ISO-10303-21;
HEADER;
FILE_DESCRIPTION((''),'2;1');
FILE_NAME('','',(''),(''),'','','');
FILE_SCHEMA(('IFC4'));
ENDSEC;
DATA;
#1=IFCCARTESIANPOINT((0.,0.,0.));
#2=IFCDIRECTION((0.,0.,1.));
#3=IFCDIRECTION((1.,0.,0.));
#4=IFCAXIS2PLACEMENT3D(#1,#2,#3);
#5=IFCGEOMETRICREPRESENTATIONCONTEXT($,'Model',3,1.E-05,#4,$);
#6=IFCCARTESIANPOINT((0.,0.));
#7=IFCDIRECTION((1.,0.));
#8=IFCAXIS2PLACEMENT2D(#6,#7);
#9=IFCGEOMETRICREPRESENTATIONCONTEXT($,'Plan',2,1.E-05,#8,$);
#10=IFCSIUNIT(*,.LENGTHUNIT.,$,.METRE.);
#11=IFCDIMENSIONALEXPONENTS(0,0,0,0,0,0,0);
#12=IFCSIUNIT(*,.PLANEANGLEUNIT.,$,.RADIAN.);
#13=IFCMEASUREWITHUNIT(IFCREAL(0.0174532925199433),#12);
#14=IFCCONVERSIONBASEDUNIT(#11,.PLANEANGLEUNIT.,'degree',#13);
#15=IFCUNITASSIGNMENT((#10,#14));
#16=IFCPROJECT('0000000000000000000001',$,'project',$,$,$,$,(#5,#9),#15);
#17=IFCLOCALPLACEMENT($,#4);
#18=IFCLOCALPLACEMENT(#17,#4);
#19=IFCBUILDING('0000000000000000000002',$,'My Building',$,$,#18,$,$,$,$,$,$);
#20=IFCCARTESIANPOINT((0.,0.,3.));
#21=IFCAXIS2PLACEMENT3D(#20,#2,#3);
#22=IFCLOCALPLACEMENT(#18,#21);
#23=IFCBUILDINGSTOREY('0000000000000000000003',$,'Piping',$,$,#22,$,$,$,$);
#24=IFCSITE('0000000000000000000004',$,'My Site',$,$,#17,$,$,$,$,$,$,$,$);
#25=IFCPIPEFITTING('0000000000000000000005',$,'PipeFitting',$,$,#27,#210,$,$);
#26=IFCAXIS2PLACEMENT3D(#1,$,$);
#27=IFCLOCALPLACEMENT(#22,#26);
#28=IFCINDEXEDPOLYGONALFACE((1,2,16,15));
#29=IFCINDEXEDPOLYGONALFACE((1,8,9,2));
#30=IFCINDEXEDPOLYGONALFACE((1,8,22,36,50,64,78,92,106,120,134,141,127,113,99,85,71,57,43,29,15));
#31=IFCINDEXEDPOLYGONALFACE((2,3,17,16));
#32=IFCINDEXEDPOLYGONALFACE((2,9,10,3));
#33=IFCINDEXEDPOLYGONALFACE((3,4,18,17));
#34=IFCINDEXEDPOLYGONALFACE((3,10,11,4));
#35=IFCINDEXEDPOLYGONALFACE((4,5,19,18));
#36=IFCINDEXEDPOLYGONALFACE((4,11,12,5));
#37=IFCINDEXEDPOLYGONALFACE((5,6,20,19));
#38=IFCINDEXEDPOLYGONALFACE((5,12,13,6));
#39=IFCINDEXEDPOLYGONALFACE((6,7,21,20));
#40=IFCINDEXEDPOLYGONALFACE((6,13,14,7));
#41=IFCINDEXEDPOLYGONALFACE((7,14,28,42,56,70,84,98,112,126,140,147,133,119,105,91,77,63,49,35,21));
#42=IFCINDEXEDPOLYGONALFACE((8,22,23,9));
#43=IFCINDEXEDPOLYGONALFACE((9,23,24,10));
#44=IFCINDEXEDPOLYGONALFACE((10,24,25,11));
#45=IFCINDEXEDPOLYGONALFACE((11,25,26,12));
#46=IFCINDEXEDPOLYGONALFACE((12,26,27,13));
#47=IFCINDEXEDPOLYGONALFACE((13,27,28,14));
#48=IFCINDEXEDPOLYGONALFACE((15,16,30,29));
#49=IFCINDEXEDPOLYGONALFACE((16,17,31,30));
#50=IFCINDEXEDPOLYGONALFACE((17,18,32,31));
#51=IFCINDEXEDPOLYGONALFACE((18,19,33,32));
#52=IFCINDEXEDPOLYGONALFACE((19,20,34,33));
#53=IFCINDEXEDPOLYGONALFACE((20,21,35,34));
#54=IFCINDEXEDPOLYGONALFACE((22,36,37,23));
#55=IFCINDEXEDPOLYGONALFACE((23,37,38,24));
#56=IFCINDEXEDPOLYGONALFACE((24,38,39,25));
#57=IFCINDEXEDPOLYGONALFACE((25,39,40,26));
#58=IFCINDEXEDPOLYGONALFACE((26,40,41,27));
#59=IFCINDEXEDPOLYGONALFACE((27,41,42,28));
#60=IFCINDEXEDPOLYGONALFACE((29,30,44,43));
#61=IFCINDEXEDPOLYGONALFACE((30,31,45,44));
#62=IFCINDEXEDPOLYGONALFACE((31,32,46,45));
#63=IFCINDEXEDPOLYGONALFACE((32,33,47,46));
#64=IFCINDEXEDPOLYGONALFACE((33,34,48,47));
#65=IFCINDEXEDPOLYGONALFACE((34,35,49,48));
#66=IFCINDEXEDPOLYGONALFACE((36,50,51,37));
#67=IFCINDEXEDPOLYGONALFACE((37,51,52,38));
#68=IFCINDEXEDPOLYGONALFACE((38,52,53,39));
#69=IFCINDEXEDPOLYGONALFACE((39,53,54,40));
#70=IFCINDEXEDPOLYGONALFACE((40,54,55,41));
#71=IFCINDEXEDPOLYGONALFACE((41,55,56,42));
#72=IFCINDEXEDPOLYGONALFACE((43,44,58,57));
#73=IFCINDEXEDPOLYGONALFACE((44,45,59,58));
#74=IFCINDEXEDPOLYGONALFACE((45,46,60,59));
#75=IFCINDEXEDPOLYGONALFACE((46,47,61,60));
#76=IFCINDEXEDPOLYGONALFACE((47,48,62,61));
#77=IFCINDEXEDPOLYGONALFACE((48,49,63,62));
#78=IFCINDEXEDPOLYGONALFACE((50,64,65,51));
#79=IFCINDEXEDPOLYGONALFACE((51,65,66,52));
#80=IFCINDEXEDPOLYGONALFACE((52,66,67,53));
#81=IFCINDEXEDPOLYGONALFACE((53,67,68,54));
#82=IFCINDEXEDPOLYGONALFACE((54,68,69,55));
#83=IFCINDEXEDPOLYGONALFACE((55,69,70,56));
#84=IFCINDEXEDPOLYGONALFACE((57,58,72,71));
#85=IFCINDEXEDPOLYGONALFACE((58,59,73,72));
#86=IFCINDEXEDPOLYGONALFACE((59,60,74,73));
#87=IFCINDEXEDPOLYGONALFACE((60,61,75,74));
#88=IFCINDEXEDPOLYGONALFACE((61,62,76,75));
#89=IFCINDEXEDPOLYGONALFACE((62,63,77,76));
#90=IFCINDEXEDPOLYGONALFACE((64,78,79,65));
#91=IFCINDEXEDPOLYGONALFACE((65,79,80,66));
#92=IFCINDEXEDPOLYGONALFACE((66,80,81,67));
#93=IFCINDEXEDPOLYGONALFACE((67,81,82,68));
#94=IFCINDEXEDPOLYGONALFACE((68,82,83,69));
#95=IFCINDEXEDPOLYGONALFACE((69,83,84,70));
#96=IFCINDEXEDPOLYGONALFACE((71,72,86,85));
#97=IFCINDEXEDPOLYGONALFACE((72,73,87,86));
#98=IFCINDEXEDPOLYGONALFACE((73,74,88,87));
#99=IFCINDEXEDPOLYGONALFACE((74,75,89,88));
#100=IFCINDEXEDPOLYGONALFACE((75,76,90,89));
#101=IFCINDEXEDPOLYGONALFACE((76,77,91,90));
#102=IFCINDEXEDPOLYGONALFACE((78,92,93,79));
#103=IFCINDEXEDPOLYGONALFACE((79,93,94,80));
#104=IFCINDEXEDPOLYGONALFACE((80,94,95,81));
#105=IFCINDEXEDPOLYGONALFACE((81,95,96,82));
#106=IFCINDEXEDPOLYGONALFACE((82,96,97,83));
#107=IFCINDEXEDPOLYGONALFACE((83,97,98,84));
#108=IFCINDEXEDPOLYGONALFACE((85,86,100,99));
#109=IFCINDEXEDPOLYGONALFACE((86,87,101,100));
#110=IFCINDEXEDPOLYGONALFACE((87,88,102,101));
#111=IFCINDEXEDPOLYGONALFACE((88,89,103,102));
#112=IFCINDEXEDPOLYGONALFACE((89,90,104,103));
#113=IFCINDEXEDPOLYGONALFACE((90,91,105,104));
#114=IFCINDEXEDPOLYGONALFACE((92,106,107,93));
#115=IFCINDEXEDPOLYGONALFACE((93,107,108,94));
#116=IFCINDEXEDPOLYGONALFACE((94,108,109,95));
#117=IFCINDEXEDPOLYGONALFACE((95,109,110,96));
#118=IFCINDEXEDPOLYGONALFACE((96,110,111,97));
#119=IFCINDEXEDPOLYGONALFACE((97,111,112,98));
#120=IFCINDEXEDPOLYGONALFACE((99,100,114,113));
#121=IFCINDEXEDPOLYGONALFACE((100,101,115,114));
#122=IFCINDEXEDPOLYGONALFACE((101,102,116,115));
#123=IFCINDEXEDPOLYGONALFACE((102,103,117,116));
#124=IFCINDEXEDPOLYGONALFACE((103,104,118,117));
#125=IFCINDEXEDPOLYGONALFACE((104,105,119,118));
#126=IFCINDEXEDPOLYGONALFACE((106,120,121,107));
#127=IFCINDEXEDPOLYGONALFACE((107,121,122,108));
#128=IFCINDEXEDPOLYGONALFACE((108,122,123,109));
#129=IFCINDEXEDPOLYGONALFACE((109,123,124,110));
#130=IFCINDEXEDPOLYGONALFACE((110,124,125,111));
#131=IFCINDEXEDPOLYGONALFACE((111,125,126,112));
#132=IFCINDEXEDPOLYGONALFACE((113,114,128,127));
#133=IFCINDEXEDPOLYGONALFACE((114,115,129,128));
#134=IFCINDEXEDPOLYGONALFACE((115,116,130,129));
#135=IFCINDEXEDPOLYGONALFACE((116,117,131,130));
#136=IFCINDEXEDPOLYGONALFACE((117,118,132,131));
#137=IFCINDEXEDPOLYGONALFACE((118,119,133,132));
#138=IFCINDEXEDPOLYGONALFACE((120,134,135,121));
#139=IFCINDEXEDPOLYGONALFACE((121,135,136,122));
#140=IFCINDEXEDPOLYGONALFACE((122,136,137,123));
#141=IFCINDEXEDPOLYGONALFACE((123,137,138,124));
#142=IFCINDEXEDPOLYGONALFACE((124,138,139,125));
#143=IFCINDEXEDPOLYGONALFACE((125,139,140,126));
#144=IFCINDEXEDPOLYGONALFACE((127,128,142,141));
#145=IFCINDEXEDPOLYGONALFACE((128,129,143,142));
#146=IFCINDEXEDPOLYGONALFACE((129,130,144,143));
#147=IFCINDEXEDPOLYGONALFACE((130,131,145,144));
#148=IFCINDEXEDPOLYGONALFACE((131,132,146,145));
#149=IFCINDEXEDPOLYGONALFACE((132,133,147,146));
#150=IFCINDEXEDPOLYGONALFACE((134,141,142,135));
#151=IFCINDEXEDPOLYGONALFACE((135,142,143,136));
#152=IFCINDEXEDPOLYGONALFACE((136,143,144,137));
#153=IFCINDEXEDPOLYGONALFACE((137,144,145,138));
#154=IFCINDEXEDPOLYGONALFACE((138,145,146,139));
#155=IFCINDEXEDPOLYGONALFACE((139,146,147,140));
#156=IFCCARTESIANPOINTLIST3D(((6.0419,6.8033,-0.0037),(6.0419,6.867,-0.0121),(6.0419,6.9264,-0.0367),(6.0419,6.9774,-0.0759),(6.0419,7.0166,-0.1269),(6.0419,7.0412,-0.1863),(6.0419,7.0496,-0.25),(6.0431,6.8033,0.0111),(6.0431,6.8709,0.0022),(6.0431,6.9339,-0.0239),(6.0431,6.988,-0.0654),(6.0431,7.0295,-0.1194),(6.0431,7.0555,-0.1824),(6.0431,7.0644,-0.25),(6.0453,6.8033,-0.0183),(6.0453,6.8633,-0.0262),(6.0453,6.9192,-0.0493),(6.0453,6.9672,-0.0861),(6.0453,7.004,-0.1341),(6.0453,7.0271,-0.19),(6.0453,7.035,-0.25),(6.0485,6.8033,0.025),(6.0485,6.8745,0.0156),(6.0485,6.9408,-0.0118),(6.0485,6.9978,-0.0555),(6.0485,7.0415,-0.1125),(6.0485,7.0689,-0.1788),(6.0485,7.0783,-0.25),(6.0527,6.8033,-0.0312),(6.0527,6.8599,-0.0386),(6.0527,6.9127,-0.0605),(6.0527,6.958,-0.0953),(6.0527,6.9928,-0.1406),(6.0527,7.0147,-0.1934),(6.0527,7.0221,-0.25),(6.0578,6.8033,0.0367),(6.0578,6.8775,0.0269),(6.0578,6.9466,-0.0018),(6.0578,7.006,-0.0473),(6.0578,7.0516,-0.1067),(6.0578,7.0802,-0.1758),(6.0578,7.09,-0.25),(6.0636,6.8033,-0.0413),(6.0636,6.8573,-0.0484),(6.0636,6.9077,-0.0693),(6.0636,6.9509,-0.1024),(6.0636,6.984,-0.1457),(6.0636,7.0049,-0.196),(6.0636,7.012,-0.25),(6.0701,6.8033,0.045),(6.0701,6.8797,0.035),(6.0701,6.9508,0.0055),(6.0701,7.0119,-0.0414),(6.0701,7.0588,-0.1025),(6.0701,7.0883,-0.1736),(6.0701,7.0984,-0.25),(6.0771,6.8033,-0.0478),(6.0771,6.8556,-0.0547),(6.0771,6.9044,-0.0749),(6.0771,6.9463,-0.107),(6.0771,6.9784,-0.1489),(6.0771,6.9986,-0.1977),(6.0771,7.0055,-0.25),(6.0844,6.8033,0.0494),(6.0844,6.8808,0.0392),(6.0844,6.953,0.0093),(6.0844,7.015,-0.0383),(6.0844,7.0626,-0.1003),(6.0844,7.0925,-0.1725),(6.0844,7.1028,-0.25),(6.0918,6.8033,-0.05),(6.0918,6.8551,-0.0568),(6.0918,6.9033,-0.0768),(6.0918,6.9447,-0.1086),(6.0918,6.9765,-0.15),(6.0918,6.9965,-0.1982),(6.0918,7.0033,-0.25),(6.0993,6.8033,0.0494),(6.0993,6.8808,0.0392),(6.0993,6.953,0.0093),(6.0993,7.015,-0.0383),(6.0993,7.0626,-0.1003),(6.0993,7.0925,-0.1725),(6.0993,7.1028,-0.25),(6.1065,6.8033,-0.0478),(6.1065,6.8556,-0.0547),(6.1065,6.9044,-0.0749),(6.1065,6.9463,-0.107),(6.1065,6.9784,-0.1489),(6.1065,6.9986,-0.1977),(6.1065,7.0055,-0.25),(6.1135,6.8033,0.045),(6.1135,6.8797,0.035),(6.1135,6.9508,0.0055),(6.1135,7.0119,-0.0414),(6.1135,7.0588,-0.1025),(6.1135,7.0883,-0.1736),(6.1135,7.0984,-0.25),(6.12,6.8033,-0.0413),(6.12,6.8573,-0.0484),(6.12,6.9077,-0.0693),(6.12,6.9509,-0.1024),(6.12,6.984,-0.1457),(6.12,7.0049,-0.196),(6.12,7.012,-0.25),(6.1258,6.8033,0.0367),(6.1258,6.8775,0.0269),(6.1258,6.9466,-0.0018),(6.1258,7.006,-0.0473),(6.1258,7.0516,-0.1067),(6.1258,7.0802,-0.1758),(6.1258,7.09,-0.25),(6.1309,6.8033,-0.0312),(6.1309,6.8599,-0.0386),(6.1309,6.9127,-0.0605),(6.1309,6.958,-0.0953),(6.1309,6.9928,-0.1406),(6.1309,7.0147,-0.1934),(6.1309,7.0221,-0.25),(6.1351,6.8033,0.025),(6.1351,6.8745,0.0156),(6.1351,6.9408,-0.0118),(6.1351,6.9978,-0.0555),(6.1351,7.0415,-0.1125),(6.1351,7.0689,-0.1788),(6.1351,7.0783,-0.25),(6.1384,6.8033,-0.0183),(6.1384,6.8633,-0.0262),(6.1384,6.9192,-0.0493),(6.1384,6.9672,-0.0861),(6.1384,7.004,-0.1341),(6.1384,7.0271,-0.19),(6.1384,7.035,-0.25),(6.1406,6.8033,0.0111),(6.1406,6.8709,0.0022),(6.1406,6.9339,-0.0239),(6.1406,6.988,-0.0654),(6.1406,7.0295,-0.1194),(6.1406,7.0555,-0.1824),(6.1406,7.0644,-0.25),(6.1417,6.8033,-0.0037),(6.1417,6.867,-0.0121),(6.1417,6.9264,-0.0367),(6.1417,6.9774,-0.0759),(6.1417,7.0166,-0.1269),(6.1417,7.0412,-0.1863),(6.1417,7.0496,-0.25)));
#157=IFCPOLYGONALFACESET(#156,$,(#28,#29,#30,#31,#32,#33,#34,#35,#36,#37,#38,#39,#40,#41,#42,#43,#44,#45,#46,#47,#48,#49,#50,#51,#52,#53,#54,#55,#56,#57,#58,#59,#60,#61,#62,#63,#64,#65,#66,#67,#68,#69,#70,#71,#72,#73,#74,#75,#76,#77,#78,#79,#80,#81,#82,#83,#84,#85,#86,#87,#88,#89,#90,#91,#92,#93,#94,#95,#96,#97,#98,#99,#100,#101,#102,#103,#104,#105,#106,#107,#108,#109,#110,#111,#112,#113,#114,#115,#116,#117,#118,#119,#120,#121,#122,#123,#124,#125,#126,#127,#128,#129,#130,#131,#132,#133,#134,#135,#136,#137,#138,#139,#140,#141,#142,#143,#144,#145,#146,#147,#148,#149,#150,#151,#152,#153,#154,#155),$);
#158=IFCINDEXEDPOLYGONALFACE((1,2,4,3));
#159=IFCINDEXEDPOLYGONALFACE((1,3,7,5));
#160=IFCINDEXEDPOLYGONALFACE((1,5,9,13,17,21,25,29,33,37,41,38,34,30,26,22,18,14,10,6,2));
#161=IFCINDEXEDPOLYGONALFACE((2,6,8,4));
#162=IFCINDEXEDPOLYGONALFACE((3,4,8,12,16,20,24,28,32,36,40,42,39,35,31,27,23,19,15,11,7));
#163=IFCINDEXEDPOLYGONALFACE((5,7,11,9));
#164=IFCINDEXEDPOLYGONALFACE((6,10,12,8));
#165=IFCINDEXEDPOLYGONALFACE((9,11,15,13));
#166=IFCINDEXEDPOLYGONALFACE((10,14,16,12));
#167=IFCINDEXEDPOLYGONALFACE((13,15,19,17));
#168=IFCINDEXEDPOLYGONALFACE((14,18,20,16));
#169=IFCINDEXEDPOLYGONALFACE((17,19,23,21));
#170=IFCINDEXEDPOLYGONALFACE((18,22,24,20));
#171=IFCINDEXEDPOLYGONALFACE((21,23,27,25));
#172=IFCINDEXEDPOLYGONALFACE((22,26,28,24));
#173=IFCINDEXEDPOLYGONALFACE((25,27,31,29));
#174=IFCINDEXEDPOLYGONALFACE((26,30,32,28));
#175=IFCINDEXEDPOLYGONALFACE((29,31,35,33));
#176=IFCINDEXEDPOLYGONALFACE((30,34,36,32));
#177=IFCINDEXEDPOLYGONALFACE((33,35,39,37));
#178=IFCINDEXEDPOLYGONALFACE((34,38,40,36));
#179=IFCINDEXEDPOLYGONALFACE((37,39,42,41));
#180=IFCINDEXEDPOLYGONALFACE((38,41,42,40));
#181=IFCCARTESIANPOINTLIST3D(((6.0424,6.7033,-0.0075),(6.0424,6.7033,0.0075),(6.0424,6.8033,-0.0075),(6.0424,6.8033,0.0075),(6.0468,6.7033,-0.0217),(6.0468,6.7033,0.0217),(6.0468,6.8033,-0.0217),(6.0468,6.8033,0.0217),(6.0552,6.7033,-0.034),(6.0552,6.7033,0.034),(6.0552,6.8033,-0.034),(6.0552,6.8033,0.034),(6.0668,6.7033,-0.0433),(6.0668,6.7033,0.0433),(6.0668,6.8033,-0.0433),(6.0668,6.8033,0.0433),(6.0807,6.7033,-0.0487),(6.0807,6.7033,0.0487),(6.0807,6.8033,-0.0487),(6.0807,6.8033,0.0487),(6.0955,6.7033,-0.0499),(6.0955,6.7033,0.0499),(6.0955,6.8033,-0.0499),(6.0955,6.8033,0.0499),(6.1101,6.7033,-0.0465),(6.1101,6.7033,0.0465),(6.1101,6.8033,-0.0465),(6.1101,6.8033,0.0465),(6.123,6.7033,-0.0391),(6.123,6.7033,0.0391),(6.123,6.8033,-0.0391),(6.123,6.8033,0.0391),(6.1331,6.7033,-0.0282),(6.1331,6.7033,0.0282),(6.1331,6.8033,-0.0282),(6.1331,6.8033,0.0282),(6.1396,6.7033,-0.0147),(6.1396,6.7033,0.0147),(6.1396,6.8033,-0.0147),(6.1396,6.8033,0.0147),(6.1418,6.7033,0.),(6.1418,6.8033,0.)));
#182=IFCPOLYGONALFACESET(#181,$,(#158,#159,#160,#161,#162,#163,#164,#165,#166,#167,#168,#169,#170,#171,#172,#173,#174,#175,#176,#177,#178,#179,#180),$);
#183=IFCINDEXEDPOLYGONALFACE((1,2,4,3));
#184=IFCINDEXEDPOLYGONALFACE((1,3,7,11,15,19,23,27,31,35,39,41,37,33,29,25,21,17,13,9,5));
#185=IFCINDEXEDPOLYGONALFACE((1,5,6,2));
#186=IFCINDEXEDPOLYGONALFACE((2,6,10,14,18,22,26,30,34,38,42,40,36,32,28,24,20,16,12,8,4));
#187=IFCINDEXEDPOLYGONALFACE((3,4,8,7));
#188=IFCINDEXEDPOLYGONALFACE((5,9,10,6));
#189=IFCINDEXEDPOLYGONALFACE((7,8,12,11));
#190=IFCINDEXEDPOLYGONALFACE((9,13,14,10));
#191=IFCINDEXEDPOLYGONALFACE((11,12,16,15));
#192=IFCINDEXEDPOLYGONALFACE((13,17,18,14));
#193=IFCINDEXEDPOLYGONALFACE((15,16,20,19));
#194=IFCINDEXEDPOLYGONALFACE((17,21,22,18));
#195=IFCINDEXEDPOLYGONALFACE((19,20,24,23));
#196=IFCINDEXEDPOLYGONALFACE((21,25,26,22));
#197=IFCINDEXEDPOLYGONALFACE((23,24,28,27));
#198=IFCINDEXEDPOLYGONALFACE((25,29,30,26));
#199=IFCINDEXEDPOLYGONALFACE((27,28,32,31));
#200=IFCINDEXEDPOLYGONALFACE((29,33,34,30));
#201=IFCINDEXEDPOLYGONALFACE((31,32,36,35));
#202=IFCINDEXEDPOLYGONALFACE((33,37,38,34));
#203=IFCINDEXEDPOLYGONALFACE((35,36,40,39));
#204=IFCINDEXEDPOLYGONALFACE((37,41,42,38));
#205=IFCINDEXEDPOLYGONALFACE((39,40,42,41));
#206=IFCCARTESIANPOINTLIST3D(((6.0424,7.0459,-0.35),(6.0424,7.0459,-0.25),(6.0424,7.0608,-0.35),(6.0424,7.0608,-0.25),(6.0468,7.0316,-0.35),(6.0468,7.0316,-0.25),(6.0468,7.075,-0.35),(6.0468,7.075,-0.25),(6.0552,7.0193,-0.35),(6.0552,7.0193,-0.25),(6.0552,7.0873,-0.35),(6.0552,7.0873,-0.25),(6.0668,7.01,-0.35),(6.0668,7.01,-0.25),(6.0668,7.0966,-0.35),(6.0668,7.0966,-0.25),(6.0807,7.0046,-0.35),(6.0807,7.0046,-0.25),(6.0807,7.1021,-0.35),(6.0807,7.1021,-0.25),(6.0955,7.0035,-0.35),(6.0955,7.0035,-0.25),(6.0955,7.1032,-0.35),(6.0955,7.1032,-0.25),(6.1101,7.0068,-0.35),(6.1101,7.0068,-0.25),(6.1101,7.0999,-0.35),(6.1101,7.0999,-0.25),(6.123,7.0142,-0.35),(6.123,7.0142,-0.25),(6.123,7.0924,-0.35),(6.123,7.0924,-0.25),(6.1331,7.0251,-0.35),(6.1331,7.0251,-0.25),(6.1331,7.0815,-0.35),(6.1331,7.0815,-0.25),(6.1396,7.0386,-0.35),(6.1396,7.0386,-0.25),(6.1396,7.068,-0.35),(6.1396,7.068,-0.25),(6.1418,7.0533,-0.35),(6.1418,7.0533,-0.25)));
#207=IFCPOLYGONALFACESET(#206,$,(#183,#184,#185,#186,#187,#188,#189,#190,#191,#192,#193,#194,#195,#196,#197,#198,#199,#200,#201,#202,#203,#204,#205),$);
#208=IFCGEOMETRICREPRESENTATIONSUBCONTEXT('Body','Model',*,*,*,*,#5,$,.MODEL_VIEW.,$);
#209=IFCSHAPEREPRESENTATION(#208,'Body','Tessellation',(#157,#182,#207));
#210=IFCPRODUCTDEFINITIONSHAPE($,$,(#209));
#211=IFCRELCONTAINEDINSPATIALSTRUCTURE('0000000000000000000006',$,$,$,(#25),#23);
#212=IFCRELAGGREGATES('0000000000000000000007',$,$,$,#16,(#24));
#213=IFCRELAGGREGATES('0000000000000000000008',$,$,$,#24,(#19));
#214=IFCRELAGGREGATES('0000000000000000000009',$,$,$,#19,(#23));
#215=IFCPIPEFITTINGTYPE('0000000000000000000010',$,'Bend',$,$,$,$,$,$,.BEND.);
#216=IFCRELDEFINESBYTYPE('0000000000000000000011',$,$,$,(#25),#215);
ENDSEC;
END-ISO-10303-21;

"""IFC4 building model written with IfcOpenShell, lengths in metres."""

from ifc_helpers import new_model, entity, si_unit, converted_unit, frame, origin_with_axes, origin_2d_with_axis, place, context, subcontext, project, spatial, circle, extrude, source, transform, mapped, type_object, type_shapes, element, save


model = new_model("IFC4")

# Units and contexts
model_context = context("Model", 3, precision=1e-05, world=origin_with_axes())
plan_context = context("Plan", 2, precision=1e-05, world=origin_2d_with_axis())
body_context = subcontext(model_context, "Body", "Model", "MODEL_VIEW")
ifc_project = project(units=[si_unit("LENGTHUNIT", "METRE"), converted_unit("PLANEANGLEUNIT", "degree", entity("IfcReal", 0.0174532925199433), si_unit("PLANEANGLEUNIT", "RADIAN"), dimensions=[0, 0, 0, 0, 0, 0, 0])], contexts=[model_context, plan_context])

# Site, building, storey
site_placement = place(None, origin_with_axes())
site = spatial("IfcSite", under=ifc_project, at=site_placement, Name="My Site")
building_placement = place(site_placement, origin_with_axes())
building = spatial("IfcBuilding", under=site, at=building_placement, Name="My Building")
storey_placement = place(building_placement, frame((0.0, 0.0, 3.0), z_axis=(0.0, 0.0, 1.0), x_axis=(1.0, 0.0, 0.0)))
storey = spatial("IfcBuildingStorey", under=building, at=storey_placement, Name="Piping")

# Shared definitions
pipe_fitting_type = type_object("IfcPipeFittingType", Name="Bend", PredefinedType="BEND")
shared_shape = source(origin_with_axes(), body_context, "Body", "SolidModel", [
    entity("IfcSweptDiskSolid", entity("IfcIndexedPolyCurve", entity("IfcCartesianPointList3D", [[0.0, 0.0, -0.1], [0.0, -0.0732, -0.2768], [0.0, -0.25, -0.35]]), [entity("IfcArcIndex", [1, 2, 3])]), 0.05),
    extrude(circle(Radius=0.05), origin_with_axes(), (0.0, 0.0, -1.0), 0.1),
    extrude(circle(Radius=0.05), frame((0.0, -0.25, -0.35), z_axis=(0.0, -1.0, 0.0), x_axis=(1.0, 0.0, 0.0)), (0.0, 0.0, 1.0), 0.1),
])
type_shapes(pipe_fitting_type, [shared_shape])

# Pipe fitting
for number, where, z_axis, x_axis, name in (
    (1, (6.0918, 6.7033, 0.0), (0.0, -1.0, 0.0), (1.0, 0.0, 0.0), "PipeFitting"),
):
    element("IfcPipeFitting", number, at=place(storey_placement, frame(where, z_axis=z_axis, x_axis=x_axis)), inside=storey, type_object=pipe_fitting_type, Name=name, context=body_context, shape_type="MappedRepresentation", body=[
        mapped(shared_shape, transform((0.0, 0.0, 0.0), x_axis=(1.0, 0.0, 0.0), y_axis=(0.0, 1.0, 0.0), z_axis=(0.0, 0.0, 1.0), scale=1.0)),
    ])

save(model, "model.ifc")
